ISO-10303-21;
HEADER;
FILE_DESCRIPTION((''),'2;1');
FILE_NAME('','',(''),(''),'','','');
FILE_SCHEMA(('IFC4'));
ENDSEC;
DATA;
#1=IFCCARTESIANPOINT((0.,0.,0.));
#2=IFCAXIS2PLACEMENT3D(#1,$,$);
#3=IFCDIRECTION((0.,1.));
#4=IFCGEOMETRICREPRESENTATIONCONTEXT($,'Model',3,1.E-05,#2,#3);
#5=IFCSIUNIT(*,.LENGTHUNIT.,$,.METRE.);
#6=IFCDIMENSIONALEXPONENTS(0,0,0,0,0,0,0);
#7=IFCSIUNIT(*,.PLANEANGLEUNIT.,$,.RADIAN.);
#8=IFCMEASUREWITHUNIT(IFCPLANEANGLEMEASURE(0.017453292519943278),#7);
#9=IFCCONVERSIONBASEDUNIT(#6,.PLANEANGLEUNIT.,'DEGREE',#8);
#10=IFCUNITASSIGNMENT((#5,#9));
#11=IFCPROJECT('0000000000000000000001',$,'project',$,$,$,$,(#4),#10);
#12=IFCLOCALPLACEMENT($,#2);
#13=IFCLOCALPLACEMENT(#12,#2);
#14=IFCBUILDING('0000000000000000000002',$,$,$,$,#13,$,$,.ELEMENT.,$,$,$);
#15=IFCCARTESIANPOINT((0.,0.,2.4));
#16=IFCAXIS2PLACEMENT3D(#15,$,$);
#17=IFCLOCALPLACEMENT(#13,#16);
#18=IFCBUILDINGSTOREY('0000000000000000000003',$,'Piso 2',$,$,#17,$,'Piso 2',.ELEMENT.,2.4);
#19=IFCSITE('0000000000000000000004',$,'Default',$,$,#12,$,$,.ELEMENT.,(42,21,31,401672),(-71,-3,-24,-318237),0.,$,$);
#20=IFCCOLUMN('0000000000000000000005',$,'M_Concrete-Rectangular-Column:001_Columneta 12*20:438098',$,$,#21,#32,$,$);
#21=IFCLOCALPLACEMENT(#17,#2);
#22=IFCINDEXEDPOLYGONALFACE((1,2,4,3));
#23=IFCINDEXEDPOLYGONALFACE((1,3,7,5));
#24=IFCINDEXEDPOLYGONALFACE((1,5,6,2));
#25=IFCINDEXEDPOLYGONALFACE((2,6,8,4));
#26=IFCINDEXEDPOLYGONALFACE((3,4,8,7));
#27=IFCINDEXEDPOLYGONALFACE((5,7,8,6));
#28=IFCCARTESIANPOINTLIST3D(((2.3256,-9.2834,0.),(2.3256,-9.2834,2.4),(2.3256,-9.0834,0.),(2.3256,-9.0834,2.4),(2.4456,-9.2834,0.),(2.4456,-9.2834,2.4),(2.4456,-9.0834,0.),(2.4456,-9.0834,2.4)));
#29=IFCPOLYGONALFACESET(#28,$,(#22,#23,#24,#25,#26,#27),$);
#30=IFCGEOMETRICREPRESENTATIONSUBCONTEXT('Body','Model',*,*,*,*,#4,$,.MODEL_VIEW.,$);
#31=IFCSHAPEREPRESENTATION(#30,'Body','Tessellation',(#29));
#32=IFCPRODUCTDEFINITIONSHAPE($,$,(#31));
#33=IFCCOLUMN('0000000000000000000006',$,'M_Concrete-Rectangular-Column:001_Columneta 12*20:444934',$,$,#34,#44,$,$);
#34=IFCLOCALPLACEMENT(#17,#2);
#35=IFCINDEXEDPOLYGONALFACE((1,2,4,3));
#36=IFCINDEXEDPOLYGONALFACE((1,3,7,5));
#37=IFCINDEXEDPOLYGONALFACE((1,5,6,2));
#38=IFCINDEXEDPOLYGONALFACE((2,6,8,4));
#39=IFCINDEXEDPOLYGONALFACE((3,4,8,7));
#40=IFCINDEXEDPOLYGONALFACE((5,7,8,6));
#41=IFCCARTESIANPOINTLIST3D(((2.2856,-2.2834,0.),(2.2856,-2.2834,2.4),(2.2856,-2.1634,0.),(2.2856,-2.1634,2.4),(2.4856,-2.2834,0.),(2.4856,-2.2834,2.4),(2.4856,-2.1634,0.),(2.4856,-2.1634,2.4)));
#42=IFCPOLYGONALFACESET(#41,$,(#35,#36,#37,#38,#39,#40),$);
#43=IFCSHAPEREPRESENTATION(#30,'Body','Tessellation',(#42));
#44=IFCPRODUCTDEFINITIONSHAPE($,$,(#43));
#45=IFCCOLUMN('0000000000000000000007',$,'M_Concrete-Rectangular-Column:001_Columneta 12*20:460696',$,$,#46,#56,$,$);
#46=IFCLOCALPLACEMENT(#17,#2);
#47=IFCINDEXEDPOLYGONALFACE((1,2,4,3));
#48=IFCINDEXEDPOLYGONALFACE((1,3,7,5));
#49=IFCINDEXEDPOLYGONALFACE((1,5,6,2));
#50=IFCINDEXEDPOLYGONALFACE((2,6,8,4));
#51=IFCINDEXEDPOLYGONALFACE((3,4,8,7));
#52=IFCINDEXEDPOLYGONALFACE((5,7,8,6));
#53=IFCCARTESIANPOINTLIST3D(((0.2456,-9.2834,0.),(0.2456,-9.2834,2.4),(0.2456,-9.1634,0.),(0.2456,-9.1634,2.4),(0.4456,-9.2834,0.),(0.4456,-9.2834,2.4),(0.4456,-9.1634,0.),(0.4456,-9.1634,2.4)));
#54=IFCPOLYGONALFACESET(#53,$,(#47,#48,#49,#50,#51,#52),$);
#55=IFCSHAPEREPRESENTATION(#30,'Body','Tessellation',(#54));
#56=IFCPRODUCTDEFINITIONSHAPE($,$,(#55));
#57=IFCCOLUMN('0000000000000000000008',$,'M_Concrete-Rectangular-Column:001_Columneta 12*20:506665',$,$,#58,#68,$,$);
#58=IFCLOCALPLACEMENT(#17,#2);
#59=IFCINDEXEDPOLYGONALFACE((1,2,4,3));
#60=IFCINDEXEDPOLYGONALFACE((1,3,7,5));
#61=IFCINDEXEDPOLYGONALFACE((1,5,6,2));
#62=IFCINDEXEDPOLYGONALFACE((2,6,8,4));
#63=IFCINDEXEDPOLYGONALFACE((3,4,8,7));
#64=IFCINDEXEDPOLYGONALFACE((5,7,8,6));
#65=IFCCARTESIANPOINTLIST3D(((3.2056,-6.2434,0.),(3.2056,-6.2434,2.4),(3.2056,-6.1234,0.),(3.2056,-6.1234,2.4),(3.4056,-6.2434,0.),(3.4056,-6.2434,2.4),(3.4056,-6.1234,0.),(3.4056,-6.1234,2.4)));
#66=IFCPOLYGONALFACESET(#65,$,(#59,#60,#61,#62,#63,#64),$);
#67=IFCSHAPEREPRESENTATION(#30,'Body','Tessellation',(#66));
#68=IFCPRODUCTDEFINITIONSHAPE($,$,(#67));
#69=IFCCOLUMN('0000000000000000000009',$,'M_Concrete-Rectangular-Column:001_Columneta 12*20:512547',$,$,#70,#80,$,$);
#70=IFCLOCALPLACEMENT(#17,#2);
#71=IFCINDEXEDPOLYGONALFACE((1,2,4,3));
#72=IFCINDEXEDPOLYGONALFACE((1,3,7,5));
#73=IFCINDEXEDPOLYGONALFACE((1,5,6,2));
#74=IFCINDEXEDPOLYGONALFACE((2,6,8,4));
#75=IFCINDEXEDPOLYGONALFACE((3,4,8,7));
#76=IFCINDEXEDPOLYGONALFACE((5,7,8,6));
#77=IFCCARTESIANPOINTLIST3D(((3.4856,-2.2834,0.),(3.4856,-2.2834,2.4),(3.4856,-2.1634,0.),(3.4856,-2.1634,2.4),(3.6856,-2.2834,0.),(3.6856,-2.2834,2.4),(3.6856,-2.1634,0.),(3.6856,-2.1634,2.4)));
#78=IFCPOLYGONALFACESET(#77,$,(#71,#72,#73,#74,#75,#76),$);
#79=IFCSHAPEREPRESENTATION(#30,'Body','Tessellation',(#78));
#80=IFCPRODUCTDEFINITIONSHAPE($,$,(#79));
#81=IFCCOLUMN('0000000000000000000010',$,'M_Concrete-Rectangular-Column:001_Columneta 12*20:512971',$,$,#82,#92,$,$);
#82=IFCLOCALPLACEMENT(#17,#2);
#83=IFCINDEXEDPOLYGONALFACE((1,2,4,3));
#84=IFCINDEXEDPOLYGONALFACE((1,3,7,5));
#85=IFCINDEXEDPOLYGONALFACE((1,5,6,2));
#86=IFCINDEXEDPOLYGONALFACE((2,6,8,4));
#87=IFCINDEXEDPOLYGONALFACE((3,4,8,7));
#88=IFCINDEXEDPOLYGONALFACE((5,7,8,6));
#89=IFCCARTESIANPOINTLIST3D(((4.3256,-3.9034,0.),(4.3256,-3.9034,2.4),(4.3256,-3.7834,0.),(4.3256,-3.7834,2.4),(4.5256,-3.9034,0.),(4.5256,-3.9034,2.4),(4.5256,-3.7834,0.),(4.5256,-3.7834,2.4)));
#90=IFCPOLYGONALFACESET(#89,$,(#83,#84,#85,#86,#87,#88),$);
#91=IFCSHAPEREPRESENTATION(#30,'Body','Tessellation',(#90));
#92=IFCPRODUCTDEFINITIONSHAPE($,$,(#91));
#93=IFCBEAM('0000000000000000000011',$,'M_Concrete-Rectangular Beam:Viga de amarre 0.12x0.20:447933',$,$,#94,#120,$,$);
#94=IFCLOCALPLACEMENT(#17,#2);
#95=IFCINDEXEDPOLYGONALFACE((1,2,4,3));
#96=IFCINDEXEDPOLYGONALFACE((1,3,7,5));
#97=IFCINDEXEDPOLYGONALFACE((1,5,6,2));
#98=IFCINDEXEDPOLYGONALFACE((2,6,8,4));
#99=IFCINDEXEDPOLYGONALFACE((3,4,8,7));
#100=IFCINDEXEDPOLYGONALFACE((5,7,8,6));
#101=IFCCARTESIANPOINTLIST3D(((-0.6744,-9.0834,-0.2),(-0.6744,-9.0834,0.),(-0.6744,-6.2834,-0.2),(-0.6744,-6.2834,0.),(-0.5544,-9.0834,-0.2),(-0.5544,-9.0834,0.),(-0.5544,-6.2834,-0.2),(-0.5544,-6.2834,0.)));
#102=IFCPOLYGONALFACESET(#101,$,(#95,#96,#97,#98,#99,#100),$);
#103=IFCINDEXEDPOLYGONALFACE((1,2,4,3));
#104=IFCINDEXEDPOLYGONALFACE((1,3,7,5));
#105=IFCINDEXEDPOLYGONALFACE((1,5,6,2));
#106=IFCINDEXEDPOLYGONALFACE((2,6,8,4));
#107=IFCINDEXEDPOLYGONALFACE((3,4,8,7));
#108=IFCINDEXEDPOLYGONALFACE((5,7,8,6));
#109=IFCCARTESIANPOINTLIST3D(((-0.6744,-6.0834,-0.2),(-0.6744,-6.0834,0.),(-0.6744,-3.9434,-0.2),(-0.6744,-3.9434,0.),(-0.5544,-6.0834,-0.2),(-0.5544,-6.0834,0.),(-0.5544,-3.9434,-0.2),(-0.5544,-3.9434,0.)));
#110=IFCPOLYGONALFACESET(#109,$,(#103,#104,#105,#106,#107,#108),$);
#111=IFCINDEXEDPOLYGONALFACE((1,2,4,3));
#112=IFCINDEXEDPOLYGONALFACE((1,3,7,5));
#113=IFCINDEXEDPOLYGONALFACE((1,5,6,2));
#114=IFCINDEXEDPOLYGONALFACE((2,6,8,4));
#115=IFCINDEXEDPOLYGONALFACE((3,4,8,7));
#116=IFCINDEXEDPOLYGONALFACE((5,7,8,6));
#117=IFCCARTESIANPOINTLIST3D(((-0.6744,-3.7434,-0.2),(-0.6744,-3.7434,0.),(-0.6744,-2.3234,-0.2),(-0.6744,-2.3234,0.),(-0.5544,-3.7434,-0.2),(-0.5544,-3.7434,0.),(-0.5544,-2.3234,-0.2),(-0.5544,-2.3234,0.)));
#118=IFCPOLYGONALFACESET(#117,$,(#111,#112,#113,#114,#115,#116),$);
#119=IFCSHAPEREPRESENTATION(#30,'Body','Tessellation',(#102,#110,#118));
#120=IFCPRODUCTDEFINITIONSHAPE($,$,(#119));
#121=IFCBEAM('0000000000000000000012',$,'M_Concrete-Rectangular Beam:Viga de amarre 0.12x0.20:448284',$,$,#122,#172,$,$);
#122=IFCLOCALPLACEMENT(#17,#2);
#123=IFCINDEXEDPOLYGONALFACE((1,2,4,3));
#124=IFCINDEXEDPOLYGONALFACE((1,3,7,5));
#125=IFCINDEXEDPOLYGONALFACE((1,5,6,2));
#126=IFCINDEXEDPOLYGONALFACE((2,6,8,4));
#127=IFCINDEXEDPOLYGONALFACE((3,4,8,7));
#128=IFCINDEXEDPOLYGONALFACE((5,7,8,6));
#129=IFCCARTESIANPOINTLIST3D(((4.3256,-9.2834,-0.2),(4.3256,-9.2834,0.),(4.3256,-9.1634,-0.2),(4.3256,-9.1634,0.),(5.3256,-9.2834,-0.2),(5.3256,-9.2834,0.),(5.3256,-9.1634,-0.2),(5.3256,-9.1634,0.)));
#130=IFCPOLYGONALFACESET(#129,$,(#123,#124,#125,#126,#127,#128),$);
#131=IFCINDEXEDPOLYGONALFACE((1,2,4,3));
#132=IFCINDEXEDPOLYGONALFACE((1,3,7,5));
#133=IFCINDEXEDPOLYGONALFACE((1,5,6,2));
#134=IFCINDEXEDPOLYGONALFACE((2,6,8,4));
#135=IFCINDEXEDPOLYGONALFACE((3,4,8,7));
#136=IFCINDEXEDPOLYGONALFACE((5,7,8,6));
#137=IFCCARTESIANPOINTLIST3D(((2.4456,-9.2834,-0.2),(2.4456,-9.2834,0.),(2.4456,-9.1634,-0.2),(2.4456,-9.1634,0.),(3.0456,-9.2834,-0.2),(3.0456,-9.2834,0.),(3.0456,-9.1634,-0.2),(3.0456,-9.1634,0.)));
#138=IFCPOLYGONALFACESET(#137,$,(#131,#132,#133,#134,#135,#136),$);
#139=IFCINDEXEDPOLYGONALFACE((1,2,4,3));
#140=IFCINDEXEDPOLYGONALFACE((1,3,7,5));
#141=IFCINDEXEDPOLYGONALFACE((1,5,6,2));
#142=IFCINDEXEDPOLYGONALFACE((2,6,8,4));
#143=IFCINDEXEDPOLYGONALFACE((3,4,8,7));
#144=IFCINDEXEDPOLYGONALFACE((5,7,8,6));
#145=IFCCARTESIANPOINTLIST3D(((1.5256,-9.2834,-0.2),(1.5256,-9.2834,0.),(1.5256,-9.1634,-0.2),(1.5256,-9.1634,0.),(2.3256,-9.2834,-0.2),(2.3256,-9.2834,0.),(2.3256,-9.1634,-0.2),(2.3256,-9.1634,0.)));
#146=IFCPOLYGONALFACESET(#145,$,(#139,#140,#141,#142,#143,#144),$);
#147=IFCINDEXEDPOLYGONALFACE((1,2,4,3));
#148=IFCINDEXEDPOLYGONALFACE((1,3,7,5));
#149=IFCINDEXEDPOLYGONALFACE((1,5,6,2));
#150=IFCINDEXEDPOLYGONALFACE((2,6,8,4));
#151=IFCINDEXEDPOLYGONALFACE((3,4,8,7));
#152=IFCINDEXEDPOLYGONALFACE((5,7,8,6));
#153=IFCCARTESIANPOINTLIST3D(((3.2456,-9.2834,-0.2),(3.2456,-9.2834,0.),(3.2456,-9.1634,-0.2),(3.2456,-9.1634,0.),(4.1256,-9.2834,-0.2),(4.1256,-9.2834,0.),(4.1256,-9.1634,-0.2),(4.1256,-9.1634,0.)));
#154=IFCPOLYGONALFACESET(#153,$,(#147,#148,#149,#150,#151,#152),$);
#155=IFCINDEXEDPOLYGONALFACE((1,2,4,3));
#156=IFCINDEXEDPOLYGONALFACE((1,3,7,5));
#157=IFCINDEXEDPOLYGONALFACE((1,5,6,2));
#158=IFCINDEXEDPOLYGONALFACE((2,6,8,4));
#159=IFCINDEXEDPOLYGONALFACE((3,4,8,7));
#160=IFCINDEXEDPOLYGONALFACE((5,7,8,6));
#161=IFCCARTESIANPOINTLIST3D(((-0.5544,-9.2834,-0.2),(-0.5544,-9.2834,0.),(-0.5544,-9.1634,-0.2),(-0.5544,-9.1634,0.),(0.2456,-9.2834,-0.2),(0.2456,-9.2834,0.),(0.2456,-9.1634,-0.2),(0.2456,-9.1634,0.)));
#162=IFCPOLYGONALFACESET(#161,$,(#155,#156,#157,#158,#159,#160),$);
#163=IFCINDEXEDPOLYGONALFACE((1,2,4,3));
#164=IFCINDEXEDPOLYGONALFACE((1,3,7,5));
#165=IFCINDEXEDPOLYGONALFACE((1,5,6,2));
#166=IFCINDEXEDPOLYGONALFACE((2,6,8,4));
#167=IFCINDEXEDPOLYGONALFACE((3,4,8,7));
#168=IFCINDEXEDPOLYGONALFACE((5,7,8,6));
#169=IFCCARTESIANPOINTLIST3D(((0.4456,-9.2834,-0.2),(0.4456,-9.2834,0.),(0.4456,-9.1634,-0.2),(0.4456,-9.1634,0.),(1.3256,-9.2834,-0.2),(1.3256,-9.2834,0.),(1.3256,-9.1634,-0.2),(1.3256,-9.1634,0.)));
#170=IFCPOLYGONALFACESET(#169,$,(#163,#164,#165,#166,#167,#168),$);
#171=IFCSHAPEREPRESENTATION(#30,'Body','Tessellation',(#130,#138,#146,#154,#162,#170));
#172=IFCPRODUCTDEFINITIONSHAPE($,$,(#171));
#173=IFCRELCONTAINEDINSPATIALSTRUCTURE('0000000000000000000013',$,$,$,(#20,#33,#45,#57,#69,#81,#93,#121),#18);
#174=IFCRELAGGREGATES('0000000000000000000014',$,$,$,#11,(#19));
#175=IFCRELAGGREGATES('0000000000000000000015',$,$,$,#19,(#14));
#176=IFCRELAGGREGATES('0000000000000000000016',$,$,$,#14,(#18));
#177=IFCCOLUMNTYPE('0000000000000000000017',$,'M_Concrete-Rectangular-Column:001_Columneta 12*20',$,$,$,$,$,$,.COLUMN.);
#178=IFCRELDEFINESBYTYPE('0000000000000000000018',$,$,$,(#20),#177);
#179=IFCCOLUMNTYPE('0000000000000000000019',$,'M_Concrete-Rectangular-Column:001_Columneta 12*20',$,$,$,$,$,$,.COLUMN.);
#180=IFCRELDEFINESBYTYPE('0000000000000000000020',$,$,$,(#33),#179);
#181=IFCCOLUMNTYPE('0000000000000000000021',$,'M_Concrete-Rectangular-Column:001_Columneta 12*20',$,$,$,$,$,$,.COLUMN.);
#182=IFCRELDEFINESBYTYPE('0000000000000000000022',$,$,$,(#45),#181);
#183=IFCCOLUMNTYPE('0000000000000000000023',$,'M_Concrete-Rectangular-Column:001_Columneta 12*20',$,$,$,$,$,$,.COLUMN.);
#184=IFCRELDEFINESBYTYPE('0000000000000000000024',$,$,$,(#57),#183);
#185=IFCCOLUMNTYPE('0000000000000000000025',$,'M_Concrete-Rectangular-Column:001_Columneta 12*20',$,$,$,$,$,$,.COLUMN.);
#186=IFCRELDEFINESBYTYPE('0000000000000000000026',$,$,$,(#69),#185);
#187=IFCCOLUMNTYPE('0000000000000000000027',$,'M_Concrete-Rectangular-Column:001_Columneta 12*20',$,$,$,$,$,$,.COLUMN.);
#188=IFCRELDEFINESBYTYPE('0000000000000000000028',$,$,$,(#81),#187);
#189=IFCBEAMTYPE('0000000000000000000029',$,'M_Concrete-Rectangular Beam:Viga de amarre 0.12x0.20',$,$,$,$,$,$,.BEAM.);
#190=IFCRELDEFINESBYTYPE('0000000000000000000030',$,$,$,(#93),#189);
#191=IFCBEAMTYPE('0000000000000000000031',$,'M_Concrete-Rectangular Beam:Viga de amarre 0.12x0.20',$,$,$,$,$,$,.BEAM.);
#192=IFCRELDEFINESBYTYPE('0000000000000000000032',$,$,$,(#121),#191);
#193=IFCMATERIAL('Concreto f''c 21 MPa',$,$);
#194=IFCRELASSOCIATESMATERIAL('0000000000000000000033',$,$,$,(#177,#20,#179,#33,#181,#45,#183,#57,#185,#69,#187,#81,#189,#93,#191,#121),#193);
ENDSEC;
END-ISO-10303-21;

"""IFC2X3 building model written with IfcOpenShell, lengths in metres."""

from ifc_helpers import new_model, entity, si_unit, converted_unit, direction, frame, frame_2d, origin, place, context, subcontext, project, spatial, rectangle, extrude, source, transform, mapped, material, type_object, type_shapes, element, save


model = new_model("IFC2X3")

# Units and contexts
model_context = context("Model", 3, precision=1e-05, world=origin(), true_north=direction((0.0, 1.0)))
body_context = subcontext(model_context, "Body", "Model", "MODEL_VIEW")
ifc_project = project(units=[si_unit("LENGTHUNIT", "METRE"), converted_unit("PLANEANGLEUNIT", "DEGREE", entity("IfcPlaneAngleMeasure", 0.017453292519943278), si_unit("PLANEANGLEUNIT", "RADIAN"), dimensions=[0, 0, 0, 0, 0, 0, 0])], contexts=[model_context])

# Site, building, storey
site_placement = place(None, origin())
site = spatial("IfcSite", under=ifc_project, at=site_placement, Name="Default", CompositionType="ELEMENT", RefLatitude=(42, 21, 31, 401672), RefLongitude=(-71, -3, -24, -318237), RefElevation=0.0)
building_placement = place(site_placement, origin())
building = spatial("IfcBuilding", under=site, at=building_placement, CompositionType="ELEMENT")
storey_placement = place(building_placement, frame((0.0, 0.0, 2.4)))
storey = spatial("IfcBuildingStorey", under=building, at=storey_placement, Name="Piso 2", LongName="Piso 2", CompositionType="ELEMENT", Elevation=2.4)

# Columns
ifc_material_1 = material(Name="Concreto f'c 21 MPa")
column_type_1 = type_object("IfcColumnType", Name="M_Concrete-Rectangular-Column:001_Columneta 12*20", PredefinedType="COLUMN", material=ifc_material_1)
shared_shape_1 = source(origin(), body_context, "Body", "SweptSolid", [
    extrude(rectangle(XDim=0.12, YDim=0.2, at=frame_2d((0.0, 0.0), x_axis=(1.0, 0.0))), frame((2.3856, -9.1834, 2.4), z_axis=(0.0, 0.0, 1.0), x_axis=(-1.0, 0.0, 0.0)), (0.0, 0.0, 1.0), 2.4),
])
type_shapes(column_type_1, [shared_shape_1])
column_1_placement = place(storey_placement, frame((0.0, 0.0, -2.4)))
element("IfcColumn", 1, at=column_1_placement, inside=storey, type_object=column_type_1, material=ifc_material_1, Name="M_Concrete-Rectangular-Column:001_Columneta 12*20:438098", context=body_context, shape_type="MappedRepresentation", body=[
    mapped(shared_shape_1, transform((0.0, 0.0, 0.0), scale=1.0)),
])
column_type_2 = type_object("IfcColumnType", Name="M_Concrete-Rectangular-Column:001_Columneta 12*20", PredefinedType="COLUMN", material=ifc_material_1)
shared_shape_2 = source(origin(), body_context, "Body", "SweptSolid", [
    extrude(rectangle(XDim=0.12, YDim=0.2, at=frame_2d((0.0, 0.0), x_axis=(1.0, 0.0))), frame((2.3856, -2.2234, 2.4), z_axis=(0.0, 0.0, 1.0), x_axis=(0.0, -1.0, 0.0)), (0.0, 0.0, 1.0), 2.4),
])
type_shapes(column_type_2, [shared_shape_2])
column_2_placement = place(storey_placement, frame((0.0, 0.0, -2.4)))
element("IfcColumn", 2, at=column_2_placement, inside=storey, type_object=column_type_2, material=ifc_material_1, Name="M_Concrete-Rectangular-Column:001_Columneta 12*20:444934", context=body_context, shape_type="MappedRepresentation", body=[
    mapped(shared_shape_2, transform((0.0, 0.0, 0.0), scale=1.0)),
])
column_type_3 = type_object("IfcColumnType", Name="M_Concrete-Rectangular-Column:001_Columneta 12*20", PredefinedType="COLUMN", material=ifc_material_1)
shared_shape_3 = source(origin(), body_context, "Body", "SweptSolid", [
    extrude(rectangle(XDim=0.12, YDim=0.2, at=frame_2d((0.0, 0.0), x_axis=(1.0, 0.0))), frame((0.3456, -9.2234, 2.4), z_axis=(0.0, 0.0, 1.0), x_axis=(0.0, -1.0, 0.0)), (0.0, 0.0, 1.0), 2.4),
])
type_shapes(column_type_3, [shared_shape_3])
column_3_placement = place(storey_placement, frame((0.0, 0.0, -2.4)))
element("IfcColumn", 3, at=column_3_placement, inside=storey, type_object=column_type_3, material=ifc_material_1, Name="M_Concrete-Rectangular-Column:001_Columneta 12*20:460696", context=body_context, shape_type="MappedRepresentation", body=[
    mapped(shared_shape_3, transform((0.0, 0.0, 0.0), scale=1.0)),
])
column_type_4 = type_object("IfcColumnType", Name="M_Concrete-Rectangular-Column:001_Columneta 12*20", PredefinedType="COLUMN", material=ifc_material_1)
shared_shape_4 = source(origin(), body_context, "Body", "SweptSolid", [
    extrude(rectangle(XDim=0.12, YDim=0.2, at=frame_2d((0.0, 0.0), x_axis=(1.0, 0.0))), frame((3.3056, -6.1834, 2.4), z_axis=(0.0, 0.0, 1.0), x_axis=(0.0, -1.0, 0.0)), (0.0, 0.0, 1.0), 2.4),
])
type_shapes(column_type_4, [shared_shape_4])
column_4_placement = place(storey_placement, frame((0.0, 0.0, -2.4)))
element("IfcColumn", 4, at=column_4_placement, inside=storey, type_object=column_type_4, material=ifc_material_1, Name="M_Concrete-Rectangular-Column:001_Columneta 12*20:506665", context=body_context, shape_type="MappedRepresentation", body=[
    mapped(shared_shape_4, transform((0.0, 0.0, 0.0), scale=1.0)),
])
column_type_5 = type_object("IfcColumnType", Name="M_Concrete-Rectangular-Column:001_Columneta 12*20", PredefinedType="COLUMN", material=ifc_material_1)
shared_shape_5 = source(origin(), body_context, "Body", "SweptSolid", [
    extrude(rectangle(XDim=0.12, YDim=0.2, at=frame_2d((0.0, 0.0), x_axis=(1.0, 0.0))), frame((3.5856, -2.2234, 2.4), z_axis=(0.0, 0.0, 1.0), x_axis=(0.0, -1.0, 0.0)), (0.0, 0.0, 1.0), 2.4),
])
type_shapes(column_type_5, [shared_shape_5])
column_5_placement = place(storey_placement, frame((0.0, 0.0, -2.4)))
element("IfcColumn", 5, at=column_5_placement, inside=storey, type_object=column_type_5, material=ifc_material_1, Name="M_Concrete-Rectangular-Column:001_Columneta 12*20:512547", context=body_context, shape_type="MappedRepresentation", body=[
    mapped(shared_shape_5, transform((0.0, 0.0, 0.0), scale=1.0)),
])
column_type_6 = type_object("IfcColumnType", Name="M_Concrete-Rectangular-Column:001_Columneta 12*20", PredefinedType="COLUMN", material=ifc_material_1)
shared_shape_6 = source(origin(), body_context, "Body", "SweptSolid", [
    extrude(rectangle(XDim=0.12, YDim=0.2, at=frame_2d((0.0, 0.0), x_axis=(1.0, 0.0))), frame((4.4256, -3.8434, 2.4), z_axis=(0.0, 0.0, 1.0), x_axis=(0.0, 1.0, 0.0)), (0.0, 0.0, 1.0), 2.4),
])
type_shapes(column_type_6, [shared_shape_6])
column_6_placement = place(storey_placement, frame((0.0, 0.0, -2.4)))
element("IfcColumn", 6, at=column_6_placement, inside=storey, type_object=column_type_6, material=ifc_material_1, Name="M_Concrete-Rectangular-Column:001_Columneta 12*20:512971", context=body_context, shape_type="MappedRepresentation", body=[
    mapped(shared_shape_6, transform((0.0, 0.0, 0.0), scale=1.0)),
])

# Beams
beam_type_1 = type_object("IfcBeamType", Name="M_Concrete-Rectangular Beam:Viga de amarre 0.12x0.20", PredefinedType="BEAM", material=ifc_material_1)
shared_shape_7 = source(origin(), body_context, "Body", "SweptSolid", [
    extrude(rectangle(XDim=0.2, YDim=0.12, at=frame_2d((0.0, 0.0), x_axis=(0.0, 1.0))), frame((-0.6144, -6.2834, 2.3), z_axis=(0.0, -1.0, 0.0), x_axis=(-1.0, 0.0, 0.0)), (0.0, 0.0, 1.0), 2.8),
    extrude(rectangle(XDim=0.2, YDim=0.12, at=frame_2d((0.0, 0.0), x_axis=(0.0, 1.0))), frame((-0.6144, -3.9434, 2.3), z_axis=(0.0, -1.0, 0.0), x_axis=(-1.0, 0.0, 0.0)), (0.0, 0.0, 1.0), 2.14),
    extrude(rectangle(XDim=0.2, YDim=0.12, at=frame_2d((0.0, 0.0), x_axis=(0.0, 1.0))), frame((-0.6144, -2.3234, 2.3), z_axis=(0.0, -1.0, 0.0), x_axis=(-1.0, 0.0, 0.0)), (0.0, 0.0, 1.0), 1.42),
])
type_shapes(beam_type_1, [shared_shape_7])
beam_1_placement = place(storey_placement, frame((0.0, 0.0, -2.4)))
element("IfcBeam", 7, at=beam_1_placement, inside=storey, type_object=beam_type_1, material=ifc_material_1, Name="M_Concrete-Rectangular Beam:Viga de amarre 0.12x0.20:447933", context=body_context, shape_type="MappedRepresentation", body=[
    mapped(shared_shape_7, transform((0.0, 0.0, 0.0), scale=1.0)),
])
beam_type_2 = type_object("IfcBeamType", Name="M_Concrete-Rectangular Beam:Viga de amarre 0.12x0.20", PredefinedType="BEAM", material=ifc_material_1)
shared_shape_8 = source(origin(), body_context, "Body", "SweptSolid", [
    extrude(rectangle(XDim=0.2, YDim=0.12, at=frame_2d((0.0, 0.0), x_axis=(1.0, 0.0))), frame((4.3256, -9.2234, 2.3), z_axis=(1.0, 0.0, 0.0), x_axis=(0.0, 0.0, -1.0)), (0.0, 0.0, 1.0), 1.0),
    extrude(rectangle(XDim=0.2, YDim=0.12, at=frame_2d((0.0, 0.0), x_axis=(1.0, 0.0))), frame((2.4456, -9.2234, 2.3), z_axis=(1.0, 0.0, 0.0), x_axis=(0.0, 0.0, -1.0)), (0.0, 0.0, 1.0), 0.6),
    extrude(rectangle(XDim=0.2, YDim=0.12, at=frame_2d((0.0, 0.0), x_axis=(1.0, 0.0))), frame((1.5256, -9.2234, 2.3), z_axis=(1.0, 0.0, 0.0), x_axis=(0.0, 0.0, -1.0)), (0.0, 0.0, 1.0), 0.8),
    extrude(rectangle(XDim=0.2, YDim=0.12, at=frame_2d((0.0, 0.0), x_axis=(1.0, 0.0))), frame((3.2456, -9.2234, 2.3), z_axis=(1.0, 0.0, 0.0), x_axis=(0.0, 0.0, -1.0)), (0.0, 0.0, 1.0), 0.88),
    extrude(rectangle(XDim=0.2, YDim=0.12, at=frame_2d((0.0, 0.0), x_axis=(1.0, 0.0))), frame((-0.5544, -9.2234, 2.3), z_axis=(1.0, 0.0, 0.0), x_axis=(0.0, 0.0, -1.0)), (0.0, 0.0, 1.0), 0.8),
    extrude(rectangle(XDim=0.2, YDim=0.12, at=frame_2d((0.0, 0.0), x_axis=(1.0, 0.0))), frame((0.4456, -9.2234, 2.3), z_axis=(1.0, 0.0, 0.0), x_axis=(0.0, 0.0, -1.0)), (0.0, 0.0, 1.0), 0.88),
])
type_shapes(beam_type_2, [shared_shape_8])
beam_2_placement = place(storey_placement, frame((0.0, 0.0, -2.4)))
element("IfcBeam", 8, at=beam_2_placement, inside=storey, type_object=beam_type_2, material=ifc_material_1, Name="M_Concrete-Rectangular Beam:Viga de amarre 0.12x0.20:448284", context=body_context, shape_type="MappedRepresentation", body=[
    mapped(shared_shape_8, transform((0.0, 0.0, 0.0), scale=1.0)),
])

save(model, "model.ifc")
